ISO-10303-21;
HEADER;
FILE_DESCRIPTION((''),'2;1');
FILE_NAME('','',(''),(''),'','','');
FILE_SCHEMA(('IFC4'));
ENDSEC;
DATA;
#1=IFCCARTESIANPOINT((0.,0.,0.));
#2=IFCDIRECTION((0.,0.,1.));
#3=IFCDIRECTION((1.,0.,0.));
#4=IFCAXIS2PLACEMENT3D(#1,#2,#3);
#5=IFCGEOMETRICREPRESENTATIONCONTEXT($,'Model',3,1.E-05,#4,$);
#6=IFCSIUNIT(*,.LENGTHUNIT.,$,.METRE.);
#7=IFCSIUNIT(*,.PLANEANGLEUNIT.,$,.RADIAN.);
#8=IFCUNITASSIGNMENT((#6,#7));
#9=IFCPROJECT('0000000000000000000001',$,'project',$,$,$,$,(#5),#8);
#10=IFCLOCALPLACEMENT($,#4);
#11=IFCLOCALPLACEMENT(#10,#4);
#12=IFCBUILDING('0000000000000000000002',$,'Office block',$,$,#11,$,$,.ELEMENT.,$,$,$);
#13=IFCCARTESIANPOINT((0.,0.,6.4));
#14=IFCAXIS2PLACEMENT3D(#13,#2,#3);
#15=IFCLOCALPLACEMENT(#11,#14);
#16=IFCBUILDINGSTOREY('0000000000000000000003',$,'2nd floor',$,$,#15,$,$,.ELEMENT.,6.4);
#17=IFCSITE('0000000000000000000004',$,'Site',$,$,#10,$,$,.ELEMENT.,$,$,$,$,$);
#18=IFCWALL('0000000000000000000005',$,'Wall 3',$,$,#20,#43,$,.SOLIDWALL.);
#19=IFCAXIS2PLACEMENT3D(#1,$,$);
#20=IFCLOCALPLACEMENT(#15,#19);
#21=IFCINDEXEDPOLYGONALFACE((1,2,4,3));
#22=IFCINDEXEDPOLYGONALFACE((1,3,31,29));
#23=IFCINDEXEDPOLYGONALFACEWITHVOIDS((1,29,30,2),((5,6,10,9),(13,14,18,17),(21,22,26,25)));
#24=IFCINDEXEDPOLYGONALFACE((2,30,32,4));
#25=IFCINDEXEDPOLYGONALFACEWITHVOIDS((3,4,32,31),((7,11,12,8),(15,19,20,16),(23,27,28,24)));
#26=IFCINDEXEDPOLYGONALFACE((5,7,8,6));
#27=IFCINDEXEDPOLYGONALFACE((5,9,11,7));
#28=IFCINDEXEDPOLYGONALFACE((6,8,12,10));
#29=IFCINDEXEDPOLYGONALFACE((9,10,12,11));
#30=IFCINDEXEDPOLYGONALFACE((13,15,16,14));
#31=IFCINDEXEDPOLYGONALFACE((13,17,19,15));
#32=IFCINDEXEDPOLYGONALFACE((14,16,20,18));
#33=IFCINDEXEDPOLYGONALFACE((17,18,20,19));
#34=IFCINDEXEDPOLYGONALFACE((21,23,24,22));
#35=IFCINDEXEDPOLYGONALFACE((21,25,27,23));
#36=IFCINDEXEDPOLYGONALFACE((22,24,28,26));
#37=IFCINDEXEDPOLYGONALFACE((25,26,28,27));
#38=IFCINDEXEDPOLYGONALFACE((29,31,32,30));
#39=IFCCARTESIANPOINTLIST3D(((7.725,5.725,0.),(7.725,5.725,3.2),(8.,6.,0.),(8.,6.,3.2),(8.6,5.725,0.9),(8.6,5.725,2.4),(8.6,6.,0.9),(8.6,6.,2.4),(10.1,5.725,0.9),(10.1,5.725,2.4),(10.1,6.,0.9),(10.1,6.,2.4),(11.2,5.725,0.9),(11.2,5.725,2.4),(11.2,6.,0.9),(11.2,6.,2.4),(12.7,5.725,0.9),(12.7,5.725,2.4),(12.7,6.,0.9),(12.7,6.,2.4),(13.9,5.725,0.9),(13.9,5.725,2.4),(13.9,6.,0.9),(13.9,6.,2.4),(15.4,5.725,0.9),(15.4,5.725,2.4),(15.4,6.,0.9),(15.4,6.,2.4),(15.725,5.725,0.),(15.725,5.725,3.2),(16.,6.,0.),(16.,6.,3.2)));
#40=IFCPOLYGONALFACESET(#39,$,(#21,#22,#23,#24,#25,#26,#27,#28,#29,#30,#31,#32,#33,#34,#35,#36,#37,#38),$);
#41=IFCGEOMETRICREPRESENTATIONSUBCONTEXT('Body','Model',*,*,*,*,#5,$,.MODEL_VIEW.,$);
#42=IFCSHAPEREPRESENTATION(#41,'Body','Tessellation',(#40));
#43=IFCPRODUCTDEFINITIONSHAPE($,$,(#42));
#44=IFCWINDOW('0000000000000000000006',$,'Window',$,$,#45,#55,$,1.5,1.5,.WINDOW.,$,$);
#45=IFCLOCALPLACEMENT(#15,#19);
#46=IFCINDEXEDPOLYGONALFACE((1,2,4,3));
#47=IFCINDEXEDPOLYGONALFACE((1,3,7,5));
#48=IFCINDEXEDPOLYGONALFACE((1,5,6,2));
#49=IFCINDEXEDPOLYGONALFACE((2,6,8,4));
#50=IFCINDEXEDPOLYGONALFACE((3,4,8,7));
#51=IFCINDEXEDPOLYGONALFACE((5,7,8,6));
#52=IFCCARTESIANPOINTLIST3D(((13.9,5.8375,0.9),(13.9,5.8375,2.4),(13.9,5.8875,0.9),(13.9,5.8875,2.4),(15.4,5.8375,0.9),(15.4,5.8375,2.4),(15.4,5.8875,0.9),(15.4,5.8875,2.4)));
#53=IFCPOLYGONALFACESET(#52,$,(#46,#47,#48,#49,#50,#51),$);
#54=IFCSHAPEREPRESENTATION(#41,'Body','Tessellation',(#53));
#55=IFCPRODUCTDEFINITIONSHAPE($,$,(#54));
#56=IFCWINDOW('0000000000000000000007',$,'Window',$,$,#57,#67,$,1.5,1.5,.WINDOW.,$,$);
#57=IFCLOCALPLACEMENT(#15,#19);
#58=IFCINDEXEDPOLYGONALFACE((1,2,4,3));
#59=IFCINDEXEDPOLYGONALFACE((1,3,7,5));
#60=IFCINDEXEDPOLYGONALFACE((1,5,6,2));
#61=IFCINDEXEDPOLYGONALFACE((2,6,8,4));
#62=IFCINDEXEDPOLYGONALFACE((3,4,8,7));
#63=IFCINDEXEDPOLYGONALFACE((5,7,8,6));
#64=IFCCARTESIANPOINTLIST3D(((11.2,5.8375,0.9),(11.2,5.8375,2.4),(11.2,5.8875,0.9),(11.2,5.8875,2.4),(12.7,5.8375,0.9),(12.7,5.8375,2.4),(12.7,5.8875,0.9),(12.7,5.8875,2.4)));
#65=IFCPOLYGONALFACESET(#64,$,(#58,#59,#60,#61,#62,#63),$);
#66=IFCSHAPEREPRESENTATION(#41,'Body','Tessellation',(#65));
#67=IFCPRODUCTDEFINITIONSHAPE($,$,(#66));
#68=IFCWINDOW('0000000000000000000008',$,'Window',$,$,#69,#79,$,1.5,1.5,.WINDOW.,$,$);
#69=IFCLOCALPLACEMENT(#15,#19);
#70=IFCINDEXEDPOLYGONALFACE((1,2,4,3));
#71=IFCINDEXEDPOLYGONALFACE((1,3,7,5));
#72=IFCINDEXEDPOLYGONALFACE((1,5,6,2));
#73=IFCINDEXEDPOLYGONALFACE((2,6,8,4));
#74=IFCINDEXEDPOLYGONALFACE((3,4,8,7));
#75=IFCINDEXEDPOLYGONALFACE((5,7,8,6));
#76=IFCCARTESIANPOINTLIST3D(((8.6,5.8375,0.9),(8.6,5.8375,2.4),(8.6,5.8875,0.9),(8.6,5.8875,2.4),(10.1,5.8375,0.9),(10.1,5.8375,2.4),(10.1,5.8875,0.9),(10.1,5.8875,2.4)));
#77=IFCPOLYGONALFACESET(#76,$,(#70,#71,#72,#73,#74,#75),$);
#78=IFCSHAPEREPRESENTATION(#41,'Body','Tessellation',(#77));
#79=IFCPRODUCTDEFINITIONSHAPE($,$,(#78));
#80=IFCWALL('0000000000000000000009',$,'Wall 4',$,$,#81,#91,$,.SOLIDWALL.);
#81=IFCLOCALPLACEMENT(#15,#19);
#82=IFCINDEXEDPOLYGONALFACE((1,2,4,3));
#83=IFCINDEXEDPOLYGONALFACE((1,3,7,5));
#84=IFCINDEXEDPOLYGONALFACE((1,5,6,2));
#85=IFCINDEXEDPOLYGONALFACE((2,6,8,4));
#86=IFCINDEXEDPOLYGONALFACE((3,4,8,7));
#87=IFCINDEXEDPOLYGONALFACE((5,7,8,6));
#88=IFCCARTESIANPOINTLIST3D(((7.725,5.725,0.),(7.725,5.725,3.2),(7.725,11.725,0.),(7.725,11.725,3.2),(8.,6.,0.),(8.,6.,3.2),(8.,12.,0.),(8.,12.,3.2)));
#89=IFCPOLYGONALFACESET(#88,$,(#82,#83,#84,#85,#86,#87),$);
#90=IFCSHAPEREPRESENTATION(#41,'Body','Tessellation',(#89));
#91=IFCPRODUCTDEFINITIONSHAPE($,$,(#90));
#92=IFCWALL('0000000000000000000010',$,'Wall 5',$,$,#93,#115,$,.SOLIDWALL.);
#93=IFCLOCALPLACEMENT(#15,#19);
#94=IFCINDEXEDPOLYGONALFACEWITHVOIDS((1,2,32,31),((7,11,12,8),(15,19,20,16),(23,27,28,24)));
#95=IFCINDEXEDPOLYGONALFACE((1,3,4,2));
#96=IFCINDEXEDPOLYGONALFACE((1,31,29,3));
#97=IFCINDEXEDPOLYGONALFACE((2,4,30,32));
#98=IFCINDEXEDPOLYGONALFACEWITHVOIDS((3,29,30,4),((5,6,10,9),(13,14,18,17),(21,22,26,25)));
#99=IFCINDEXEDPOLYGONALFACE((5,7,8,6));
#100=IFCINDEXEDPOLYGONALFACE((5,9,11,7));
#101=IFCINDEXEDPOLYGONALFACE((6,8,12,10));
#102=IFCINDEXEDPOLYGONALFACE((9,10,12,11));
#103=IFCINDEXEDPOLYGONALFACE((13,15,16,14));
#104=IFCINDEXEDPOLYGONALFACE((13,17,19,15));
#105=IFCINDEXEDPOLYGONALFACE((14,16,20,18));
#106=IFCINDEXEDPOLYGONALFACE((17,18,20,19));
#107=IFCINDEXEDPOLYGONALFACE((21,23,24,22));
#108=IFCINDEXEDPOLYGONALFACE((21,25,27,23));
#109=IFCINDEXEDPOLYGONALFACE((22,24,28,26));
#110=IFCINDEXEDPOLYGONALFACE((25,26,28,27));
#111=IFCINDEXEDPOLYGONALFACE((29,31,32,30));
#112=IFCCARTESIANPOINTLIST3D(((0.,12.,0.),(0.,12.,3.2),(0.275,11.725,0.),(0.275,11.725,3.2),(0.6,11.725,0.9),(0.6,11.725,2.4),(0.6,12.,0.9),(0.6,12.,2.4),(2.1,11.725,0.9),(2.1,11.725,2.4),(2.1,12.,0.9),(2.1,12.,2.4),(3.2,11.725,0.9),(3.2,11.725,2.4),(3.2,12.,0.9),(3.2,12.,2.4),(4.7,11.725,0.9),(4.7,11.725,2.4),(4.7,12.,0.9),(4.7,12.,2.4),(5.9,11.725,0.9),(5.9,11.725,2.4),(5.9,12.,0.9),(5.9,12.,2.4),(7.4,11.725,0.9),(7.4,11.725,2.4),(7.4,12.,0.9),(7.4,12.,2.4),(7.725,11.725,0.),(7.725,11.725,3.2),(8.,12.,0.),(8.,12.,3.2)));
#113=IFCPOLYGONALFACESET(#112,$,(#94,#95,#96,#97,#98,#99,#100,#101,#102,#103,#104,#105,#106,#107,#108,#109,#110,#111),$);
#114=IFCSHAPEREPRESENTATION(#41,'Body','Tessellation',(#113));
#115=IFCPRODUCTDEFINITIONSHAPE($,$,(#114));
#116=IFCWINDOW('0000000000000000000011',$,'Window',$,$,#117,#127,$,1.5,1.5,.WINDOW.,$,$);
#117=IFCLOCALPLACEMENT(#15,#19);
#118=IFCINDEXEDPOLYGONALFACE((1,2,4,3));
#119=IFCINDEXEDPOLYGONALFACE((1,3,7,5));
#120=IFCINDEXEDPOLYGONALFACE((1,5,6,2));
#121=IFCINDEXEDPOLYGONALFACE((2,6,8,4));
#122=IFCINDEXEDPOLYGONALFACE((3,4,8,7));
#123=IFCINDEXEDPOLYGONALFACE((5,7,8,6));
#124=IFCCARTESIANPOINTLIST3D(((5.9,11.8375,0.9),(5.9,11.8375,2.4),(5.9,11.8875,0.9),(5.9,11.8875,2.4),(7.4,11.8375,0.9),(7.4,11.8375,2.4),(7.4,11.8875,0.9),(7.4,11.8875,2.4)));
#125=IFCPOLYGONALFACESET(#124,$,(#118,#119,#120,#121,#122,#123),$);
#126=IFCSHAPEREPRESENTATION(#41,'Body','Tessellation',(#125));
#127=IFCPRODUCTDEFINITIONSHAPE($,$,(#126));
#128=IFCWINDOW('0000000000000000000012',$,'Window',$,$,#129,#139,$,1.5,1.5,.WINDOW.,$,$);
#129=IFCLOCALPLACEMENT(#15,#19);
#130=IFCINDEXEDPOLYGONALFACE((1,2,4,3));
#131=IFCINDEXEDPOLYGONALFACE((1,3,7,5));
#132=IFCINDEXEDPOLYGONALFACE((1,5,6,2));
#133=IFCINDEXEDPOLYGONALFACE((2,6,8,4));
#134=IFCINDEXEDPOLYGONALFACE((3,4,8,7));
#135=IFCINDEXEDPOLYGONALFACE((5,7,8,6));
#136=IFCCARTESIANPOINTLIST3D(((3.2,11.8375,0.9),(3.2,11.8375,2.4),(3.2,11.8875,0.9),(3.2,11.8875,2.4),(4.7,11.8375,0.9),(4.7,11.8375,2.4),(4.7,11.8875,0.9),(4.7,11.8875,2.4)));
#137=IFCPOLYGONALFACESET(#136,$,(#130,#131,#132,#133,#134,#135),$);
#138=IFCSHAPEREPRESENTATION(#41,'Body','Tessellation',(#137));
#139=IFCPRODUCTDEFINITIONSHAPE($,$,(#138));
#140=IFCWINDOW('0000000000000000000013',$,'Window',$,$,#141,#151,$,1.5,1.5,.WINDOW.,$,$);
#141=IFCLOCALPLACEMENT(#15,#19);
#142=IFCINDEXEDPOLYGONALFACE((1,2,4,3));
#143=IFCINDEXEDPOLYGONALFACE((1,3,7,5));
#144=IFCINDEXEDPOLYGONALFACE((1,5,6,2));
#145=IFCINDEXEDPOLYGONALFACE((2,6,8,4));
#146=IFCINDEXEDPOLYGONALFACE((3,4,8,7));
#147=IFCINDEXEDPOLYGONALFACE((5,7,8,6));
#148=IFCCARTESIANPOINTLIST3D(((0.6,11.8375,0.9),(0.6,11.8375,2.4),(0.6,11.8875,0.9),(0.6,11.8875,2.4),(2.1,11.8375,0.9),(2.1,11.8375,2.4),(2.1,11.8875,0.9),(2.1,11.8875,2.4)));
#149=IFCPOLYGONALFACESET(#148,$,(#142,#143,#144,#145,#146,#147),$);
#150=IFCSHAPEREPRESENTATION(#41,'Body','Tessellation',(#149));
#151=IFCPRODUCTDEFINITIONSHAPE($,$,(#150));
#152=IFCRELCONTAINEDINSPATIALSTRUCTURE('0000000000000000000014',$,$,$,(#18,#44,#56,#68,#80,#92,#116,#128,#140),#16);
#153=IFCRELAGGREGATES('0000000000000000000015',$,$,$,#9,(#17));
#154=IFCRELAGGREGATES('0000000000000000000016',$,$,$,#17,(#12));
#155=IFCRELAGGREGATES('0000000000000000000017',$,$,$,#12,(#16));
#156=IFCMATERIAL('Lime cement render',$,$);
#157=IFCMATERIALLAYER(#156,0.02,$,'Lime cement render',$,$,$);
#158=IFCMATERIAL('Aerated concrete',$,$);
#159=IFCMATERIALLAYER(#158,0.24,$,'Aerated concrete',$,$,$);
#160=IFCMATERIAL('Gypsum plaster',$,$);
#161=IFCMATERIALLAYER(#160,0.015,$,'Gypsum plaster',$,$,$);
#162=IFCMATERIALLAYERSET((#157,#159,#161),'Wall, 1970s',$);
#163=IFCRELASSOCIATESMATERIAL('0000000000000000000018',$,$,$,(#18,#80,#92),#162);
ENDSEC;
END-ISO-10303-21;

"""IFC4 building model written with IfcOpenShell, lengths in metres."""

from ifc_helpers import new_model, si_unit, frame, origin_with_axes, place, context, subcontext, project, spatial, polyline, outline, extrude, material, layer, layer_set, layer_usage, element, fill, save


model = new_model("IFC4")

# Units and contexts
model_context = context("Model", 3, precision=1e-05, world=origin_with_axes())
body_context = subcontext(model_context, "Body", "Model", "MODEL_VIEW")
ifc_project = project(units=[si_unit("LENGTHUNIT", "METRE"), si_unit("PLANEANGLEUNIT", "RADIAN")], contexts=[model_context])

# Site, building, storey
site_placement = place(None, origin_with_axes())
site = spatial("IfcSite", under=ifc_project, at=site_placement, Name="Site", CompositionType="ELEMENT")
building_placement = place(site_placement, origin_with_axes())
building = spatial("IfcBuilding", under=site, at=building_placement, Name="Office block", CompositionType="ELEMENT")
storey_placement = place(building_placement, frame((0.0, 0.0, 6.4), z_axis=(0.0, 0.0, 1.0), x_axis=(1.0, 0.0, 0.0)))
storey = spatial("IfcBuildingStorey", under=building, at=storey_placement, Name="2nd floor", CompositionType="ELEMENT", Elevation=6.4)

# Wall, openings, windows
ifc_material_1 = material(Name="Lime cement render")
ifc_layer_1 = layer(ifc_material_1, 0.02, Name="Lime cement render")
ifc_material_2 = material(Name="Aerated concrete")
ifc_layer_2 = layer(ifc_material_2, 0.24, Name="Aerated concrete")
ifc_material_3 = material(Name="Gypsum plaster")
ifc_layer_3 = layer(ifc_material_3, 0.015, Name="Gypsum plaster")
ifc_layer_set = layer_set([ifc_layer_1, ifc_layer_2, ifc_layer_3], Name="Wall, 1970s")
ifc_layer_usage_1 = layer_usage(ifc_layer_set, "AXIS2", "NEGATIVE", 0.0)
wall_1_placement = place(storey_placement, origin_with_axes())
wall_1 = element("IfcWall", 1, at=wall_1_placement, inside=storey, material=ifc_layer_usage_1, Name="Wall 3", PredefinedType="SOLIDWALL", context=body_context, shape_type="SweptSolid", body=[
    extrude(outline(polyline([(16.0, 6.0), (8.0, 6.0), (7.725, 5.725), (15.725, 5.725), (16.0, 6.0)])), origin_with_axes(), (0.0, 0.0, 1.0), 3.2),
])
opening_1_placement = place(storey_placement, origin_with_axes())
opening_1 = element("IfcOpeningElement", 2, at=opening_1_placement, cuts=wall_1, PredefinedType="OPENING", context=body_context, shape_type="SweptSolid", body=[
    extrude(outline(polyline([(15.4, 6.01), (13.9, 6.01), (13.9, 5.715), (15.4, 5.715), (15.4, 6.01)])), frame((0.0, 0.0, 0.9), z_axis=(0.0, 0.0, 1.0), x_axis=(1.0, 0.0, 0.0)), (0.0, 0.0, 1.0), 1.5),
])
opening_2_placement = place(storey_placement, origin_with_axes())
opening_2 = element("IfcOpeningElement", 3, at=opening_2_placement, cuts=wall_1, PredefinedType="OPENING", context=body_context, shape_type="SweptSolid", body=[
    extrude(outline(polyline([(12.7, 6.01), (11.2, 6.01), (11.2, 5.715), (12.7, 5.715), (12.7, 6.01)])), frame((0.0, 0.0, 0.9), z_axis=(0.0, 0.0, 1.0), x_axis=(1.0, 0.0, 0.0)), (0.0, 0.0, 1.0), 1.5),
])
opening_3_placement = place(storey_placement, origin_with_axes())
opening_3 = element("IfcOpeningElement", 4, at=opening_3_placement, cuts=wall_1, PredefinedType="OPENING", context=body_context, shape_type="SweptSolid", body=[
    extrude(outline(polyline([(10.1, 6.01), (8.6, 6.01), (8.6, 5.715), (10.1, 5.715), (10.1, 6.01)])), frame((0.0, 0.0, 0.9), z_axis=(0.0, 0.0, 1.0), x_axis=(1.0, 0.0, 0.0)), (0.0, 0.0, 1.0), 1.5),
])
window_1_placement = place(storey_placement, origin_with_axes())
window_1 = element("IfcWindow", 5, at=window_1_placement, inside=storey, Name="Window", OverallHeight=1.5, OverallWidth=1.5, PredefinedType="WINDOW", context=body_context, shape_type="SweptSolid", body=[
    extrude(outline(polyline([(15.4, 5.8875), (13.9, 5.8875), (13.9, 5.8375), (15.4, 5.8375), (15.4, 5.8875)])), frame((0.0, 0.0, 0.9), z_axis=(0.0, 0.0, 1.0), x_axis=(1.0, 0.0, 0.0)), (0.0, 0.0, 1.0), 1.5),
])
fill(opening_1, window_1)
window_2_placement = place(storey_placement, origin_with_axes())
window_2 = element("IfcWindow", 6, at=window_2_placement, inside=storey, Name="Window", OverallHeight=1.5, OverallWidth=1.5, PredefinedType="WINDOW", context=body_context, shape_type="SweptSolid", body=[
    extrude(outline(polyline([(12.7, 5.8875), (11.2, 5.8875), (11.2, 5.8375), (12.7, 5.8375), (12.7, 5.8875)])), frame((0.0, 0.0, 0.9), z_axis=(0.0, 0.0, 1.0), x_axis=(1.0, 0.0, 0.0)), (0.0, 0.0, 1.0), 1.5),
])
fill(opening_2, window_2)
window_3_placement = place(storey_placement, origin_with_axes())
window_3 = element("IfcWindow", 7, at=window_3_placement, inside=storey, Name="Window", OverallHeight=1.5, OverallWidth=1.5, PredefinedType="WINDOW", context=body_context, shape_type="SweptSolid", body=[
    extrude(outline(polyline([(10.1, 5.8875), (8.6, 5.8875), (8.6, 5.8375), (10.1, 5.8375), (10.1, 5.8875)])), frame((0.0, 0.0, 0.9), z_axis=(0.0, 0.0, 1.0), x_axis=(1.0, 0.0, 0.0)), (0.0, 0.0, 1.0), 1.5),
])
fill(opening_3, window_3)

# Wall
ifc_layer_usage_2 = layer_usage(ifc_layer_set, "AXIS2", "NEGATIVE", 0.0)
wall_2_placement = place(storey_placement, origin_with_axes())
element("IfcWall", 8, at=wall_2_placement, inside=storey, material=ifc_layer_usage_2, Name="Wall 4", PredefinedType="SOLIDWALL", context=body_context, shape_type="SweptSolid", body=[
    extrude(outline(polyline([(8.0, 6.0), (8.0, 12.0), (7.725, 11.725), (7.725, 5.725), (8.0, 6.0)])), origin_with_axes(), (0.0, 0.0, 1.0), 3.2),
])

# Wall, openings, windows
ifc_layer_usage_3 = layer_usage(ifc_layer_set, "AXIS2", "NEGATIVE", 0.0)
wall_3_placement = place(storey_placement, origin_with_axes())
wall_3 = element("IfcWall", 9, at=wall_3_placement, inside=storey, material=ifc_layer_usage_3, Name="Wall 5", PredefinedType="SOLIDWALL", context=body_context, shape_type="SweptSolid", body=[
    extrude(outline(polyline([(8.0, 12.0), (0.0, 12.0), (0.275, 11.725), (7.725, 11.725), (8.0, 12.0)])), origin_with_axes(), (0.0, 0.0, 1.0), 3.2),
])
opening_4_placement = place(storey_placement, origin_with_axes())
opening_4 = element("IfcOpeningElement", 10, at=opening_4_placement, cuts=wall_3, PredefinedType="OPENING", context=body_context, shape_type="SweptSolid", body=[
    extrude(outline(polyline([(7.4, 12.01), (5.9, 12.01), (5.9, 11.715), (7.4, 11.715), (7.4, 12.01)])), frame((0.0, 0.0, 0.9), z_axis=(0.0, 0.0, 1.0), x_axis=(1.0, 0.0, 0.0)), (0.0, 0.0, 1.0), 1.5),
])
opening_5_placement = place(storey_placement, origin_with_axes())
opening_5 = element("IfcOpeningElement", 11, at=opening_5_placement, cuts=wall_3, PredefinedType="OPENING", context=body_context, shape_type="SweptSolid", body=[
    extrude(outline(polyline([(4.7, 12.01), (3.2, 12.01), (3.2, 11.715), (4.7, 11.715), (4.7, 12.01)])), frame((0.0, 0.0, 0.9), z_axis=(0.0, 0.0, 1.0), x_axis=(1.0, 0.0, 0.0)), (0.0, 0.0, 1.0), 1.5),
])
opening_6_placement = place(storey_placement, origin_with_axes())
opening_6 = element("IfcOpeningElement", 12, at=opening_6_placement, cuts=wall_3, PredefinedType="OPENING", context=body_context, shape_type="SweptSolid", body=[
    extrude(outline(polyline([(2.1, 12.01), (0.6, 12.01), (0.6, 11.715), (2.1, 11.715), (2.1, 12.01)])), frame((0.0, 0.0, 0.9), z_axis=(0.0, 0.0, 1.0), x_axis=(1.0, 0.0, 0.0)), (0.0, 0.0, 1.0), 1.5),
])
window_4_placement = place(storey_placement, origin_with_axes())
window_4 = element("IfcWindow", 13, at=window_4_placement, inside=storey, Name="Window", OverallHeight=1.5, OverallWidth=1.5, PredefinedType="WINDOW", context=body_context, shape_type="SweptSolid", body=[
    extrude(outline(polyline([(7.4, 11.8875), (5.9, 11.8875), (5.9, 11.8375), (7.4, 11.8375), (7.4, 11.8875)])), frame((0.0, 0.0, 0.9), z_axis=(0.0, 0.0, 1.0), x_axis=(1.0, 0.0, 0.0)), (0.0, 0.0, 1.0), 1.5),
])
fill(opening_4, window_4)
window_5_placement = place(storey_placement, origin_with_axes())
window_5 = element("IfcWindow", 14, at=window_5_placement, inside=storey, Name="Window", OverallHeight=1.5, OverallWidth=1.5, PredefinedType="WINDOW", context=body_context, shape_type="SweptSolid", body=[
    extrude(outline(polyline([(4.7, 11.8875), (3.2, 11.8875), (3.2, 11.8375), (4.7, 11.8375), (4.7, 11.8875)])), frame((0.0, 0.0, 0.9), z_axis=(0.0, 0.0, 1.0), x_axis=(1.0, 0.0, 0.0)), (0.0, 0.0, 1.0), 1.5),
])
fill(opening_5, window_5)
window_6_placement = place(storey_placement, origin_with_axes())
window_6 = element("IfcWindow", 15, at=window_6_placement, inside=storey, Name="Window", OverallHeight=1.5, OverallWidth=1.5, PredefinedType="WINDOW", context=body_context, shape_type="SweptSolid", body=[
    extrude(outline(polyline([(2.1, 11.8875), (0.6, 11.8875), (0.6, 11.8375), (2.1, 11.8375), (2.1, 11.8875)])), frame((0.0, 0.0, 0.9), z_axis=(0.0, 0.0, 1.0), x_axis=(1.0, 0.0, 0.0)), (0.0, 0.0, 1.0), 1.5),
])
fill(opening_6, window_6)

save(model, "model.ifc")
